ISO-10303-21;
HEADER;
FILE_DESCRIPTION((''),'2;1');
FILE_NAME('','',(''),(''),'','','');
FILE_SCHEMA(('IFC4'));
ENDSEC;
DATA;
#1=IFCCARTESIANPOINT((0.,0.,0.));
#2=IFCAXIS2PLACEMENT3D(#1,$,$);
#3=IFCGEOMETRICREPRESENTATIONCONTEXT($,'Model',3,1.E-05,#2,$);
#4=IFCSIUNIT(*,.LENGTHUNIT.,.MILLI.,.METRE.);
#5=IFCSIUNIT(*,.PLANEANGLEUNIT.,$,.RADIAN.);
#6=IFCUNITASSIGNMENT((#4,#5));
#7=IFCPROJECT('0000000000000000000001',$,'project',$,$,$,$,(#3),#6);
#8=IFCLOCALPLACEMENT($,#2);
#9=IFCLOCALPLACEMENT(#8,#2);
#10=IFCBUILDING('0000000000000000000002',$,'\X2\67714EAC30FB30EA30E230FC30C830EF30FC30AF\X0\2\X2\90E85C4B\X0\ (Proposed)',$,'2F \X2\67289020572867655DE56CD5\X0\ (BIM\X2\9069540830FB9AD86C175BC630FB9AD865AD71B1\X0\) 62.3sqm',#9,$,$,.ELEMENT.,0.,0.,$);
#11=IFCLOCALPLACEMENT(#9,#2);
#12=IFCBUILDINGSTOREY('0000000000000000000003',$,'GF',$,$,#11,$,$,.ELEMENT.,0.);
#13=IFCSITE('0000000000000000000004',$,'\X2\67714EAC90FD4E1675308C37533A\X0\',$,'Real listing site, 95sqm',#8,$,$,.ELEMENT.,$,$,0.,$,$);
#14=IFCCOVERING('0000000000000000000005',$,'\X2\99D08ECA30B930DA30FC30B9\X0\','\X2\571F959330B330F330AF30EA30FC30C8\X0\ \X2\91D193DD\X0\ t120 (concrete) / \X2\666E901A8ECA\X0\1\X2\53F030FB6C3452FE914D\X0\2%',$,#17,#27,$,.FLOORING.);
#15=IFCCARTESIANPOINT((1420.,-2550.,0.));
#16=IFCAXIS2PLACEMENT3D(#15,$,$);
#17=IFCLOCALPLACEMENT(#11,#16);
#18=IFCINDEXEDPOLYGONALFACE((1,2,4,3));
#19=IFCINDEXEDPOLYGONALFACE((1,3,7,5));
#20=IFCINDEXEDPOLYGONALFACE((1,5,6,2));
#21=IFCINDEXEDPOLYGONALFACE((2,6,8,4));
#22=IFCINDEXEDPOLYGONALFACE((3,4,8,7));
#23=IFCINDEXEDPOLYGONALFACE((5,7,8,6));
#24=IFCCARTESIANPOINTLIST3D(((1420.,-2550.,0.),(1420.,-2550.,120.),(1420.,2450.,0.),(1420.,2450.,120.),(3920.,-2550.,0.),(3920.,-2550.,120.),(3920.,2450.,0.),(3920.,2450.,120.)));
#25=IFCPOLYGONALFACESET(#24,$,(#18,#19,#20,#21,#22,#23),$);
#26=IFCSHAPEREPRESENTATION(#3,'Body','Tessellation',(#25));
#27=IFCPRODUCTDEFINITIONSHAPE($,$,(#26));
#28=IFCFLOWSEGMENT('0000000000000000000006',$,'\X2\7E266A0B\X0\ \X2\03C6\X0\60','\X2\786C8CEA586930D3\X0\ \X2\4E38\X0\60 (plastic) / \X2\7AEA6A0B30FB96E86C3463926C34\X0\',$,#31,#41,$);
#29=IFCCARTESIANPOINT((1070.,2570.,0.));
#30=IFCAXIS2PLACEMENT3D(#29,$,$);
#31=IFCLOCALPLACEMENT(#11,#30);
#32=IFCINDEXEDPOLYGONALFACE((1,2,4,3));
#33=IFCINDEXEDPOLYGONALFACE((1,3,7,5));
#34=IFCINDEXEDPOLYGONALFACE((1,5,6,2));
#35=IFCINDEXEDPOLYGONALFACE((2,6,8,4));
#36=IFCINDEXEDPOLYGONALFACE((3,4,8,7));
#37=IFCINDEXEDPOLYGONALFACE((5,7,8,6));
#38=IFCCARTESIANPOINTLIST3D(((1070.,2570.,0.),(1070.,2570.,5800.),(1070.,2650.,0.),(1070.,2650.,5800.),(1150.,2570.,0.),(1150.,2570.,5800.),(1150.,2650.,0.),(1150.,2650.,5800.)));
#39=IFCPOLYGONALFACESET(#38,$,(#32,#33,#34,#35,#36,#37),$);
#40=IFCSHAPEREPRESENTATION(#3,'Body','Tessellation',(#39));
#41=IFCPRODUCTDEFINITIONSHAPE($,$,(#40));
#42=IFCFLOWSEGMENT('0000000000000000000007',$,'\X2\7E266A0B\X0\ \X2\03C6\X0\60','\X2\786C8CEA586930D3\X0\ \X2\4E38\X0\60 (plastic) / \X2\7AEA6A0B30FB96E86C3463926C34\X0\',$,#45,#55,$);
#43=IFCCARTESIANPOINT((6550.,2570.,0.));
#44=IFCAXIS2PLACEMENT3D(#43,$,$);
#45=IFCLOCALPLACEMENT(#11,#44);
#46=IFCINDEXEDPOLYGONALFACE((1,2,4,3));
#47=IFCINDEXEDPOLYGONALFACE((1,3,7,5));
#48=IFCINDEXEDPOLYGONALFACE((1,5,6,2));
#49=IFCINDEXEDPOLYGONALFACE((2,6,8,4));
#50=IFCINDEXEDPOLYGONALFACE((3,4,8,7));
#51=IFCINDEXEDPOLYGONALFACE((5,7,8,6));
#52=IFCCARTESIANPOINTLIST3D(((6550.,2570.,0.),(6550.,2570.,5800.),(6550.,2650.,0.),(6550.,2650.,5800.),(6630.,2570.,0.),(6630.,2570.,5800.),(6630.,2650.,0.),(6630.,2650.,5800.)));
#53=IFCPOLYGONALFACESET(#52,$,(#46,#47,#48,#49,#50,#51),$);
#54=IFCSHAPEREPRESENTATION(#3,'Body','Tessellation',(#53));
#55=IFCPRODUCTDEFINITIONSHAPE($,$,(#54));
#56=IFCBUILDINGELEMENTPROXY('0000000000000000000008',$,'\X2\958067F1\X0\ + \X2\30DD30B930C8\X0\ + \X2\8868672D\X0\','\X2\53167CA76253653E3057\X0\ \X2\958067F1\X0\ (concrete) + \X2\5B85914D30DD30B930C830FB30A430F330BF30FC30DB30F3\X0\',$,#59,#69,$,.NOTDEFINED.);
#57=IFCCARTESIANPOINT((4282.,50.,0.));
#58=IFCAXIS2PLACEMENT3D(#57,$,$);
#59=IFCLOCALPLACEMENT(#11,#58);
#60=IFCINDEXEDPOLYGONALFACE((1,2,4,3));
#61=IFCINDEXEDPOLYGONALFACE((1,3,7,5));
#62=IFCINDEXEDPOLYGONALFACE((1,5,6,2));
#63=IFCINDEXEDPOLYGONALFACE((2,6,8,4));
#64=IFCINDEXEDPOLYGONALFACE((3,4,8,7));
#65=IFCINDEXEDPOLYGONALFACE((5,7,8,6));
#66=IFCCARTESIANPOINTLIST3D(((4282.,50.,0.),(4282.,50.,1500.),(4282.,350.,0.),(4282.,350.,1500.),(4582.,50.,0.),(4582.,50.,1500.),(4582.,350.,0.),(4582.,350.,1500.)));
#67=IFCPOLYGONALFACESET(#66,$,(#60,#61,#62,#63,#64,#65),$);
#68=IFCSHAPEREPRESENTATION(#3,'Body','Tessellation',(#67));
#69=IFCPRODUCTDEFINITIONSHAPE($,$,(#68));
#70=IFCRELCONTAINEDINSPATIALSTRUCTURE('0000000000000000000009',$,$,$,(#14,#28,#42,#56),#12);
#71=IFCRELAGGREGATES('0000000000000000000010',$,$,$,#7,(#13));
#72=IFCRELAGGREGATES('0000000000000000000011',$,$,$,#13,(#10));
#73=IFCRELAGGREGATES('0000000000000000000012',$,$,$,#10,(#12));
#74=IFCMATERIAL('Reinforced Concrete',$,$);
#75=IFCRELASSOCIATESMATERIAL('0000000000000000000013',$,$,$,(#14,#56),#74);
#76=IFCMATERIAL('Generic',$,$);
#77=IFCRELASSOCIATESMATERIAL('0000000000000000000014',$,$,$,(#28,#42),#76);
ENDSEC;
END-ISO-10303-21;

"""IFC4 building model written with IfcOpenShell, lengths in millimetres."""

from ifc_helpers import new_model, si_unit, frame, frame_2d, origin, place, context, project, spatial, rectangle, extrude, material, element, save


model = new_model("IFC4")

# Units and contexts
model_context = context("Model", 3, precision=1e-05, world=origin())
ifc_project = project(units=[si_unit("LENGTHUNIT", "METRE", prefix="MILLI"), si_unit("PLANEANGLEUNIT", "RADIAN")], contexts=[model_context])

# Site, building, storey
site_placement = place(None, origin())
site = spatial("IfcSite", under=ifc_project, at=site_placement, Name="東京都世田谷区", ObjectType="Real listing site, 95sqm", CompositionType="ELEMENT", RefElevation=0.0)
building_placement = place(site_placement, origin())
building = spatial("IfcBuilding", under=site, at=building_placement, Name="東京・リモートワーク2部屋 (Proposed)", ObjectType="2F 木造在来工法 (BIM適合・高気密・高断熱) 62.3sqm", CompositionType="ELEMENT", ElevationOfRefHeight=0.0, ElevationOfTerrain=0.0)
storey_placement = place(building_placement, origin())
storey = spatial("IfcBuildingStorey", under=building, at=storey_placement, Name="GF", CompositionType="ELEMENT", Elevation=0.0)

# Shared definitions
ifc_material_1 = material(Name="Reinforced Concrete")

# Covering
covering_1_placement = place(storey_placement, frame((1420.0, -2550.0, 0.0)))
element("IfcCovering", 1, at=covering_1_placement, inside=storey, material=ifc_material_1, Name="駐車スペース", Description="土間コンクリート 金鏝 t120 (concrete) / 普通車1台・水勾配2%", PredefinedType="FLOORING", context=model_context, shape_type="SweptSolid", body=[
    extrude(rectangle(XDim=2500.0, YDim=5000.0, at=frame_2d((1250.0, 2500.0))), frame((1420.0, -2550.0, 0.0)), (0.0, 0.0, 1.0), 120.0),
])

# Flow segments
ifc_material_2 = material(Name="Generic")
flow_segment_1_placement = place(storey_placement, frame((1070.0, 2570.0, 0.0)))
element("IfcFlowSegment", 2, at=flow_segment_1_placement, inside=storey, material=ifc_material_2, Name="縦樋 φ60", Description="硬質塩ビ 丸60 (plastic) / 竪樋・雨水排水", context=model_context, shape_type="SweptSolid", body=[
    extrude(rectangle(XDim=80.0, YDim=80.0, at=frame_2d((40.0, 40.0))), frame((1070.0, 2570.0, 0.0)), (0.0, 0.0, 1.0), 5800.0),
])
flow_segment_2_placement = place(storey_placement, frame((6550.0, 2570.0, 0.0)))
element("IfcFlowSegment", 3, at=flow_segment_2_placement, inside=storey, material=ifc_material_2, Name="縦樋 φ60", Description="硬質塩ビ 丸60 (plastic) / 竪樋・雨水排水", context=model_context, shape_type="SweptSolid", body=[
    extrude(rectangle(XDim=80.0, YDim=80.0, at=frame_2d((40.0, 40.0))), frame((6550.0, 2570.0, 0.0)), (0.0, 0.0, 1.0), 5800.0),
])

# Building element proxy
proxy_placement = place(storey_placement, frame((4282.0, 50.0, 0.0)))
element("IfcBuildingElementProxy", 4, at=proxy_placement, inside=storey, material=ifc_material_1, Name="門柱 + ポスト + 表札", Description="化粧打放し 門柱 (concrete) + 宅配ポスト・インターホン", PredefinedType="NOTDEFINED", context=model_context, shape_type="SweptSolid", body=[
    extrude(rectangle(XDim=300.0, YDim=300.0, at=frame_2d((150.0, 150.0))), frame((4282.0, 50.0, 0.0)), (0.0, 0.0, 1.0), 1500.0),
])

save(model, "model.ifc")
